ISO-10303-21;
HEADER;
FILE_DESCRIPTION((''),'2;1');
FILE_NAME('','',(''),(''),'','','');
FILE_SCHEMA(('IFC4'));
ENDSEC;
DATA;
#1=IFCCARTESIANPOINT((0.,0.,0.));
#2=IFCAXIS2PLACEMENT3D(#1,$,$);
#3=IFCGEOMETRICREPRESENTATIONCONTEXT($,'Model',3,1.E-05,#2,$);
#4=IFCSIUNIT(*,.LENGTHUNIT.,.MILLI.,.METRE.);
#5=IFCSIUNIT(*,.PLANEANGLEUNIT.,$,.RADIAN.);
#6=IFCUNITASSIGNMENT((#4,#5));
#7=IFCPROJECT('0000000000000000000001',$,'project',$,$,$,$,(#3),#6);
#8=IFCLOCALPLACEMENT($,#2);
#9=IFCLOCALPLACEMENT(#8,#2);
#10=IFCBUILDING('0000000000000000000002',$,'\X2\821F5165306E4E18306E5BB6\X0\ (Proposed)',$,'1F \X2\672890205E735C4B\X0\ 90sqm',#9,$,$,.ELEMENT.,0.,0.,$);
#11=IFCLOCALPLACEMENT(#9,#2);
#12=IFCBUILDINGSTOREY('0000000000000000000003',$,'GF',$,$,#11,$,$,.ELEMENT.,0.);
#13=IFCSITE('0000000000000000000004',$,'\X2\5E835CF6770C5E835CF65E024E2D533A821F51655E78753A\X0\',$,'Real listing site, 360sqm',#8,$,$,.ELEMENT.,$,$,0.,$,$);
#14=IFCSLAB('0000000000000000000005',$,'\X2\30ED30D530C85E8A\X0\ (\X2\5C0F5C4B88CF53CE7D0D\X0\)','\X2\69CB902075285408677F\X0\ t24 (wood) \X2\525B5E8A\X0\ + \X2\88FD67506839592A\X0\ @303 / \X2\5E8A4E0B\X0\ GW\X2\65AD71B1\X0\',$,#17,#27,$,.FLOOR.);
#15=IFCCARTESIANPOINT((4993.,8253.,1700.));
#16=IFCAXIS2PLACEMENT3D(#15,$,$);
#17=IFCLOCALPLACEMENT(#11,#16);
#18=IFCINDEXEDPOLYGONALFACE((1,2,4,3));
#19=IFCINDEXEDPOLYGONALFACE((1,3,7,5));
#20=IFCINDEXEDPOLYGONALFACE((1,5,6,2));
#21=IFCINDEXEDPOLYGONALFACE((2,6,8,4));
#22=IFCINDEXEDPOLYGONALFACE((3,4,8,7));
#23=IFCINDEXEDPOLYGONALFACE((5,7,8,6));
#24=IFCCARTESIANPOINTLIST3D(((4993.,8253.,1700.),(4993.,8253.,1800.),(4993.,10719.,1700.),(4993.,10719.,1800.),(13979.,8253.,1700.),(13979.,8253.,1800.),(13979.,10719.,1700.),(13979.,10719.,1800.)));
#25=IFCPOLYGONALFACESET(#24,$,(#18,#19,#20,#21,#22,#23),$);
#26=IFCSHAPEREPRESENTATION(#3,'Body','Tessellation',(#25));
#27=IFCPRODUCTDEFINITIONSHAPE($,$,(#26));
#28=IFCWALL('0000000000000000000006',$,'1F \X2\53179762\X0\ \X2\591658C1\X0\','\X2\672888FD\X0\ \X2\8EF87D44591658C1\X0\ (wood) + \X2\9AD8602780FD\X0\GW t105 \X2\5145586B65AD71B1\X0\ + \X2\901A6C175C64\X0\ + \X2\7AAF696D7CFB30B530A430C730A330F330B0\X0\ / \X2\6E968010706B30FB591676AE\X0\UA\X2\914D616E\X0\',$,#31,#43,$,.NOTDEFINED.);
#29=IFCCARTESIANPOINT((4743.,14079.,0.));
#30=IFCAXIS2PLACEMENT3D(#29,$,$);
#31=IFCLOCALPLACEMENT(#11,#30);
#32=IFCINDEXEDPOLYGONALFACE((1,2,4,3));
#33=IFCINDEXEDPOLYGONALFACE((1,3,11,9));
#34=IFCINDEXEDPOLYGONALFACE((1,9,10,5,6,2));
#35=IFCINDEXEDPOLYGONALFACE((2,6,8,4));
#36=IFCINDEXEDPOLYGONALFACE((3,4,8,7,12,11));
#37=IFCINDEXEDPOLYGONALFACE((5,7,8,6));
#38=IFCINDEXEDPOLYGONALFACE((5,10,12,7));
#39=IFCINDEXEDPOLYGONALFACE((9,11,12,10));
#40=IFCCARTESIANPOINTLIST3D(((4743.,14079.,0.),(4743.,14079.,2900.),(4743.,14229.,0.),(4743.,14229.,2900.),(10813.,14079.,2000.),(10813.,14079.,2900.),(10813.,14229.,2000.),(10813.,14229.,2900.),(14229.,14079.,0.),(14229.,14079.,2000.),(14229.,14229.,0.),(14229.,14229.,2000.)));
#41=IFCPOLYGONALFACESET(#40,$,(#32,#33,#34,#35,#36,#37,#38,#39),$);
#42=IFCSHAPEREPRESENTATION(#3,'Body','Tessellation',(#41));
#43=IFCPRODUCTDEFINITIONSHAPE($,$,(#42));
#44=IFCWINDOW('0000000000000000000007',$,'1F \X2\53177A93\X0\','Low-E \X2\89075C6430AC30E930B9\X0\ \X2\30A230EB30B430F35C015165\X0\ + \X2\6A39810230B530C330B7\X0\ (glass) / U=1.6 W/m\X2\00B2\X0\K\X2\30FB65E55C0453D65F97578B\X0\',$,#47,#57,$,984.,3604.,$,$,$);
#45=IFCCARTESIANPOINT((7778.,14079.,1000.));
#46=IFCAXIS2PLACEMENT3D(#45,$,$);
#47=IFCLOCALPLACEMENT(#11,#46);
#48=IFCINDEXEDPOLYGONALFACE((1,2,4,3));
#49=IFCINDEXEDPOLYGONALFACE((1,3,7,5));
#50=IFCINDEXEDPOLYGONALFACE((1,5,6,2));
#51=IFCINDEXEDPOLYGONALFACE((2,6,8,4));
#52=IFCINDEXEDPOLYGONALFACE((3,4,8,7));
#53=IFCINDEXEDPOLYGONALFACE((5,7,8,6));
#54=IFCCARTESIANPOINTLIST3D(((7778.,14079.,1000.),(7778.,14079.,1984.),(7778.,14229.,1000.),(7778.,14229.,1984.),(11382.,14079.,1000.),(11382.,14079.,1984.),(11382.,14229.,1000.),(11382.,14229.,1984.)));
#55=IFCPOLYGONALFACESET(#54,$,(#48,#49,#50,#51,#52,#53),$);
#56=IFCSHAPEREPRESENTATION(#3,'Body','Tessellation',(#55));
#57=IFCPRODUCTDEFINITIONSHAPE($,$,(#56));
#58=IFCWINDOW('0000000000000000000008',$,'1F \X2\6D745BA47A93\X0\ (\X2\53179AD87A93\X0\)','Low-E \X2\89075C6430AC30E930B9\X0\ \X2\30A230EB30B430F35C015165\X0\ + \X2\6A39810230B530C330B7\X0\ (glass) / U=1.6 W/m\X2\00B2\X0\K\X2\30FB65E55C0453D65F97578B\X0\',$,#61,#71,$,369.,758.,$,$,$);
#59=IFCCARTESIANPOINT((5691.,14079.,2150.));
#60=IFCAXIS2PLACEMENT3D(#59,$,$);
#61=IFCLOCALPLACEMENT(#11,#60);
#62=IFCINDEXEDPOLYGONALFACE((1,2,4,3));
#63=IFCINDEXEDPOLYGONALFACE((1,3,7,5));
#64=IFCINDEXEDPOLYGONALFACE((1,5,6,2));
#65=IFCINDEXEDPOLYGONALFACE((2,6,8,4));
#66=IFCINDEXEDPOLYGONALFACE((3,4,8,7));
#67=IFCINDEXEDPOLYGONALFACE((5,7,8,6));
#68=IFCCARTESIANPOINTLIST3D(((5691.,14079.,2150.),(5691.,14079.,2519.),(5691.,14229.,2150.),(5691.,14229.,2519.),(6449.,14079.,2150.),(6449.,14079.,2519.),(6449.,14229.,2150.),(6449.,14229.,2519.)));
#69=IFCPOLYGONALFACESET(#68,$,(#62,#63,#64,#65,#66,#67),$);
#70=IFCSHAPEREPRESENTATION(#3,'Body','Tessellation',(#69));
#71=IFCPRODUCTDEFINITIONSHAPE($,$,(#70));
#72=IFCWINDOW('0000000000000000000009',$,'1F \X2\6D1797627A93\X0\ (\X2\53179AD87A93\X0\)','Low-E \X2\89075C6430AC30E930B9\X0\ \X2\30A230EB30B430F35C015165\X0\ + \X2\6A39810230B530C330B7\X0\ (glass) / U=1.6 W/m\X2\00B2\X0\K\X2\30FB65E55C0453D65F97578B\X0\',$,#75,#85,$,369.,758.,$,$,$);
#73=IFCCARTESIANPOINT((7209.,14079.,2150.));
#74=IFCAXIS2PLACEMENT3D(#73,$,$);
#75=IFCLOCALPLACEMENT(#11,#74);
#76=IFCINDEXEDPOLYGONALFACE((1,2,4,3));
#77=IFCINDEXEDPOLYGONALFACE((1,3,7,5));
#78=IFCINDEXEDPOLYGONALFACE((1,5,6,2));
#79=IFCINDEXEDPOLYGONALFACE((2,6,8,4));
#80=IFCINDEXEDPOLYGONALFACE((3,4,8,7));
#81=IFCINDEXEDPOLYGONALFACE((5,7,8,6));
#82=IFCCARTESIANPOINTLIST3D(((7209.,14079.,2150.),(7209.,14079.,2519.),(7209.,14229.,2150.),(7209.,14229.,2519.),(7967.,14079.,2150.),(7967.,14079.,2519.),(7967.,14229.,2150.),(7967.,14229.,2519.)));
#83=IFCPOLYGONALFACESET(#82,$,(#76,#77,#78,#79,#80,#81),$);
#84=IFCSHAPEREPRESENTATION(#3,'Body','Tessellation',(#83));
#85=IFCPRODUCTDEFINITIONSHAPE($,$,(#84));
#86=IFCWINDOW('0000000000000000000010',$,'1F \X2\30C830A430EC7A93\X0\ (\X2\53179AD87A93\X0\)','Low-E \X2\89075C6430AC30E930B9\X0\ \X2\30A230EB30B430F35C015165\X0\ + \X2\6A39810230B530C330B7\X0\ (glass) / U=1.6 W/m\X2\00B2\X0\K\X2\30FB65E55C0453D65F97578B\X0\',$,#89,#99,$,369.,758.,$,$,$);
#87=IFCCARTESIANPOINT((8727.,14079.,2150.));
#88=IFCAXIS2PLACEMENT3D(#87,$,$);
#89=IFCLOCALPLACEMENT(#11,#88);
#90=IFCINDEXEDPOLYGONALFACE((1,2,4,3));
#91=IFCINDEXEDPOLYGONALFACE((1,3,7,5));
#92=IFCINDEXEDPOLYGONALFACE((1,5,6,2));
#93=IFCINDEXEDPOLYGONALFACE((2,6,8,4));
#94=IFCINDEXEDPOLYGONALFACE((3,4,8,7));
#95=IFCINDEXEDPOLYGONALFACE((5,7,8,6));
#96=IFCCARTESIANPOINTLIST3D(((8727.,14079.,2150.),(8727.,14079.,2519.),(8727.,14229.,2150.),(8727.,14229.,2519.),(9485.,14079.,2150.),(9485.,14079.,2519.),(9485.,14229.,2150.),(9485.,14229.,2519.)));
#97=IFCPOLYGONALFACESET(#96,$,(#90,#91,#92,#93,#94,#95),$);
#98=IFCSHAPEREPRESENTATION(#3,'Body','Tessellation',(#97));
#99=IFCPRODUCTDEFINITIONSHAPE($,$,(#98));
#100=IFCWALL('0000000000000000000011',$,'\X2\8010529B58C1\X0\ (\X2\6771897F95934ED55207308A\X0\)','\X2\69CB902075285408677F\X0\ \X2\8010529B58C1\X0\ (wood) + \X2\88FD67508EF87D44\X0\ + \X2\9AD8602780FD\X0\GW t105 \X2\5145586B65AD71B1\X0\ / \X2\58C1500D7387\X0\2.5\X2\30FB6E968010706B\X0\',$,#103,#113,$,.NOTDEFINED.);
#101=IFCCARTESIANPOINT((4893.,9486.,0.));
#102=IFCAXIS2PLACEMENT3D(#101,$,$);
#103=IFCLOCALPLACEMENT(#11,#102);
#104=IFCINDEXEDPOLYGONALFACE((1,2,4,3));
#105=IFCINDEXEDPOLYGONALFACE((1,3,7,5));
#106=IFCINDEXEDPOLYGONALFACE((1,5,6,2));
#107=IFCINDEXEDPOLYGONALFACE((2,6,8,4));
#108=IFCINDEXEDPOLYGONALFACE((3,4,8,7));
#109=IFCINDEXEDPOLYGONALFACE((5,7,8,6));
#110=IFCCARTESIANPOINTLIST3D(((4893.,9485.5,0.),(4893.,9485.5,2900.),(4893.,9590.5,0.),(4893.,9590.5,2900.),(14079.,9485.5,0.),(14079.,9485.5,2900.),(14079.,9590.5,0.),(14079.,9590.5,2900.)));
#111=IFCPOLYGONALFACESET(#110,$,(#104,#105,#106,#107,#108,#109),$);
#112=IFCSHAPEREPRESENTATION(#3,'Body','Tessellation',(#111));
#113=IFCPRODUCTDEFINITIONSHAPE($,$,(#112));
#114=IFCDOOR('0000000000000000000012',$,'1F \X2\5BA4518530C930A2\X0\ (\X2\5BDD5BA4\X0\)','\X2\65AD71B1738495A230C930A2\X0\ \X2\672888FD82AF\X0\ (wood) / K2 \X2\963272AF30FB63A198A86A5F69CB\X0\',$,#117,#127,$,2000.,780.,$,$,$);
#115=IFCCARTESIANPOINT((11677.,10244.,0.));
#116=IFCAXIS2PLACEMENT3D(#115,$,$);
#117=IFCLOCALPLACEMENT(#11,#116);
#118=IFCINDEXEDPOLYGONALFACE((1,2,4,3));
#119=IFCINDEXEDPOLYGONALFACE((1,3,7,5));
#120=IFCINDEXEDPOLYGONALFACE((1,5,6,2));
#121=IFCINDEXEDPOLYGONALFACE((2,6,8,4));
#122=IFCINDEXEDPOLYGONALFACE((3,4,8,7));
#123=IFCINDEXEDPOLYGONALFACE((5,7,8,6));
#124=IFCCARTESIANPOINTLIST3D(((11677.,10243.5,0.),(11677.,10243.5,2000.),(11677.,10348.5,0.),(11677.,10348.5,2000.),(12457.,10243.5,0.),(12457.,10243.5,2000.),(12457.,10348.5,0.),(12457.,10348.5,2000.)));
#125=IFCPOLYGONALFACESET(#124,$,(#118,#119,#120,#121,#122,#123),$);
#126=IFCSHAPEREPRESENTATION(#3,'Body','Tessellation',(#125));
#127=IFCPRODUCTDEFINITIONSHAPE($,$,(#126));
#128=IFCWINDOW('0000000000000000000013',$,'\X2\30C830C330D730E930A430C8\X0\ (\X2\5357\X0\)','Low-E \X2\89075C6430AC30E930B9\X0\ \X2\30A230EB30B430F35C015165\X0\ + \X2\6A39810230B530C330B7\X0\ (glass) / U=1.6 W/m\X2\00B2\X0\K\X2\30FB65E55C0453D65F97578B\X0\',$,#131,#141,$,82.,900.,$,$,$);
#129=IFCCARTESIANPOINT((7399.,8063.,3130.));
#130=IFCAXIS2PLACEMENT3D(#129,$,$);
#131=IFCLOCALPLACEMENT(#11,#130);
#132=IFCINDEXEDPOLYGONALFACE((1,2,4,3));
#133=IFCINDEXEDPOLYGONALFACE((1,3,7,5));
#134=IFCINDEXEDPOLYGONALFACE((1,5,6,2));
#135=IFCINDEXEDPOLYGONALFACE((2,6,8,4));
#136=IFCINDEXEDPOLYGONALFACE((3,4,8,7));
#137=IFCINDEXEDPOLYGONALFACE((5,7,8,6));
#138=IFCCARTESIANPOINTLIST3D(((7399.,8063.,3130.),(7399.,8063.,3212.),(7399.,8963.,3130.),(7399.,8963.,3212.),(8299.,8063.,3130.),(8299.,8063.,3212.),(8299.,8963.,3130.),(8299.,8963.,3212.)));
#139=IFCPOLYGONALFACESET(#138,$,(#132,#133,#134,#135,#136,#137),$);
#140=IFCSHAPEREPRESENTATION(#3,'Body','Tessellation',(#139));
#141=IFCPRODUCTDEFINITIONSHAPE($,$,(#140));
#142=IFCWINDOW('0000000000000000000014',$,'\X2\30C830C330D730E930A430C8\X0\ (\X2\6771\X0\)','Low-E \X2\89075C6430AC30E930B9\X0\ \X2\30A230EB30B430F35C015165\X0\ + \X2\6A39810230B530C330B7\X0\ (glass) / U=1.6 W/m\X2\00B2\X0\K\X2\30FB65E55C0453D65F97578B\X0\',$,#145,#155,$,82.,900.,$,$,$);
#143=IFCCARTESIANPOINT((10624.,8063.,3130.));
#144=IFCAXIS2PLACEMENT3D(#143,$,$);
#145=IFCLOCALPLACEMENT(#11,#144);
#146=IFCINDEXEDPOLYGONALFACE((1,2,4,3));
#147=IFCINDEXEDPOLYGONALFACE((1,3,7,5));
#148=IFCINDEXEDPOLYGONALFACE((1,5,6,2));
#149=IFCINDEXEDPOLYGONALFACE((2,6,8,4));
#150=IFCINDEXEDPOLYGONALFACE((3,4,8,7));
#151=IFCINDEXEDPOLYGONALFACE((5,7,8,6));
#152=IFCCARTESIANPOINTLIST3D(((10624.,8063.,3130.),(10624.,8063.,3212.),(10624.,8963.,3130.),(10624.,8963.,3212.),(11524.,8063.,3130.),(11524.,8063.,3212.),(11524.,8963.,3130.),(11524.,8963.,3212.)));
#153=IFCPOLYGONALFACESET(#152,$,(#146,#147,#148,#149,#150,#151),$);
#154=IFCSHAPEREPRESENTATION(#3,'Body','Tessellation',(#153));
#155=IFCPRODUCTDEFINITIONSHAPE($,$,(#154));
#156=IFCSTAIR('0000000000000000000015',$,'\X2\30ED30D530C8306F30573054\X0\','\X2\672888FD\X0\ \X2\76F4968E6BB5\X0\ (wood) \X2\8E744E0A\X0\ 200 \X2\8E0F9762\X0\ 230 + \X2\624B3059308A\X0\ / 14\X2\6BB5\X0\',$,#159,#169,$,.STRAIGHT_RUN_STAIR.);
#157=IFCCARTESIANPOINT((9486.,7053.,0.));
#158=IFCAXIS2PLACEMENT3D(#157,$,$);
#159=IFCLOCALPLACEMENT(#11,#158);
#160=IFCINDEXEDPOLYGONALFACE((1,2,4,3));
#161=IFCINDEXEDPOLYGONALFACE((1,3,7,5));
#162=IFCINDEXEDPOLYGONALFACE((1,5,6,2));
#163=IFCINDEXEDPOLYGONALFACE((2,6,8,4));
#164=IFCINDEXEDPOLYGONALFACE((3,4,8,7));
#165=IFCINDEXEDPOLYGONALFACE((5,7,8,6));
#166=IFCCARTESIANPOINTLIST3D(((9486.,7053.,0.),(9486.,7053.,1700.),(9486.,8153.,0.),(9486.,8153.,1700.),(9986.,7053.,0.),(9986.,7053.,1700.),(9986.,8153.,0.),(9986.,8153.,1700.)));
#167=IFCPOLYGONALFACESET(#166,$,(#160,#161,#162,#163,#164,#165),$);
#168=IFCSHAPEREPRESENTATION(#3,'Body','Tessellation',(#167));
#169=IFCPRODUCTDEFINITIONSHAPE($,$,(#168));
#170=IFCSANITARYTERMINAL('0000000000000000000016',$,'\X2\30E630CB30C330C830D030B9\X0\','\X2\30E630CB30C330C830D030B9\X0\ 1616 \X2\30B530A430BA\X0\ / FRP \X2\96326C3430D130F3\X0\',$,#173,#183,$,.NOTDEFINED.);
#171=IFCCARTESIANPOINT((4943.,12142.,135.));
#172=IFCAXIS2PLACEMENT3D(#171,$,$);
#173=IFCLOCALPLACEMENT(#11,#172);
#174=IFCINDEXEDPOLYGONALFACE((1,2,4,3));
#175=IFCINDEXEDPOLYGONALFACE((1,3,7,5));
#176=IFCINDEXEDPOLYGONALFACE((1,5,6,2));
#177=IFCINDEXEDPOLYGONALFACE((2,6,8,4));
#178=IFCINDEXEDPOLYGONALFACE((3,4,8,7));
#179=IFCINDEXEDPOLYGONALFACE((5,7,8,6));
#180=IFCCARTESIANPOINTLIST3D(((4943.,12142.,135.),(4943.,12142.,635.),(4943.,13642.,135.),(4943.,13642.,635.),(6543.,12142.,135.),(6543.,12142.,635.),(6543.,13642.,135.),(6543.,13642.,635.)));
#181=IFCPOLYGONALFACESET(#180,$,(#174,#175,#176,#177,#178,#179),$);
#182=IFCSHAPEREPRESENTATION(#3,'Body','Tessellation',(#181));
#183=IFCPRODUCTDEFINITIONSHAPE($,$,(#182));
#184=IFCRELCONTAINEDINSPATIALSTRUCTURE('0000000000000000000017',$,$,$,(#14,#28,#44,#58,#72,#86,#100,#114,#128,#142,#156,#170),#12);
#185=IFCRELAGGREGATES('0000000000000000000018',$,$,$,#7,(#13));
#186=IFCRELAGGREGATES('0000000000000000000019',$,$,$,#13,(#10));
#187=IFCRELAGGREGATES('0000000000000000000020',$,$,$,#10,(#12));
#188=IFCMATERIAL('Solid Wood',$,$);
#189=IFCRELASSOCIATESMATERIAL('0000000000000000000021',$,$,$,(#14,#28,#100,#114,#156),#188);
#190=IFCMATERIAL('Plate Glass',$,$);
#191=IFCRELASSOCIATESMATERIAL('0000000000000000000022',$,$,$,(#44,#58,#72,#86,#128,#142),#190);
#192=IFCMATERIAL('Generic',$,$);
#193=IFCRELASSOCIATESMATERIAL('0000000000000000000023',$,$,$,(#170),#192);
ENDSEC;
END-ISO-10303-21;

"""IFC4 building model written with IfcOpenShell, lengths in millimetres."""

from ifc_helpers import new_model, si_unit, frame, frame_2d, origin, place, context, project, spatial, rectangle, extrude, material, element, fill, save


model = new_model("IFC4")

# Units and contexts
model_context = context("Model", 3, precision=1e-05, world=origin())
ifc_project = project(units=[si_unit("LENGTHUNIT", "METRE", prefix="MILLI"), si_unit("PLANEANGLEUNIT", "RADIAN")], contexts=[model_context])

# Site, building, storey
site_placement = place(None, origin())
site = spatial("IfcSite", under=ifc_project, at=site_placement, Name="広島県広島市中区舟入幸町", ObjectType="Real listing site, 360sqm", CompositionType="ELEMENT", RefElevation=0.0)
building_placement = place(site_placement, origin())
building = spatial("IfcBuilding", under=site, at=building_placement, Name="舟入の丘の家 (Proposed)", ObjectType="1F 木造平屋 90sqm", CompositionType="ELEMENT", ElevationOfRefHeight=0.0, ElevationOfTerrain=0.0)
storey_placement = place(building_placement, origin())
storey = spatial("IfcBuildingStorey", under=building, at=storey_placement, Name="GF", CompositionType="ELEMENT", Elevation=0.0)

# Slab
ifc_material_1 = material(Name="Solid Wood")
slab_placement = place(storey_placement, frame((4993.0, 8253.0, 1700.0)))
element("IfcSlab", 1, at=slab_placement, inside=storey, material=ifc_material_1, Name="ロフト床 (小屋裏収納)", Description="構造用合板 t24 (wood) 剛床 + 製材根太 @303 / 床下 GW断熱", PredefinedType="FLOOR", context=model_context, shape_type="SweptSolid", body=[
    extrude(rectangle(XDim=8986.0, YDim=2466.0, at=frame_2d((4493.0, 1233.0))), frame((4993.0, 8253.0, 1700.0)), (0.0, 0.0, 1.0), 100.0),
])

# Wall, openings, windows
wall_1_placement = place(storey_placement, frame((4743.0, 14079.0, 0.0)))
wall_1 = element("IfcWall", 2, at=wall_1_placement, inside=storey, material=ifc_material_1, Name="1F 北面 外壁", Description="木製 軸組外壁 (wood) + 高性能GW t105 充填断熱 + 通気層 + 窯業系サイディング / 準耐火・外皮UA配慮", PredefinedType="NOTDEFINED", context=model_context, shape_type="SweptSolid", body=[
    extrude(rectangle(XDim=9486.0, YDim=150.0, at=frame_2d((4743.0, 75.0))), frame((4743.0, 14079.0, 0.0)), (0.0, 0.0, 1.0), 2900.0),
])
opening_1_placement = place(storey_placement, frame((7778.0, 14079.0, 1000.0)))
opening_1 = element("IfcOpeningElement", 3, at=opening_1_placement, cuts=wall_1, PredefinedType="NOTDEFINED", context=model_context, shape_type="SweptSolid", body=[
    extrude(rectangle(XDim=3604.0, YDim=150.0, at=frame_2d((1802.0, 75.0))), frame((7778.0, 14079.0, 1000.0)), (0.0, 0.0, 1.0), 984.0),
])
opening_2_placement = place(storey_placement, frame((5691.0, 14079.0, 2150.0)))
opening_2 = element("IfcOpeningElement", 4, at=opening_2_placement, cuts=wall_1, PredefinedType="NOTDEFINED", context=model_context, shape_type="SweptSolid", body=[
    extrude(rectangle(XDim=758.0, YDim=150.0, at=frame_2d((379.0, 75.0))), frame((5691.0, 14079.0, 2150.0)), (0.0, 0.0, 1.0), 369.0),
])
opening_3_placement = place(storey_placement, frame((7209.0, 14079.0, 2150.0)))
opening_3 = element("IfcOpeningElement", 5, at=opening_3_placement, cuts=wall_1, PredefinedType="NOTDEFINED", context=model_context, shape_type="SweptSolid", body=[
    extrude(rectangle(XDim=758.0, YDim=150.0, at=frame_2d((379.0, 75.0))), frame((7209.0, 14079.0, 2150.0)), (0.0, 0.0, 1.0), 369.0),
])
opening_4_placement = place(storey_placement, frame((8727.0, 14079.0, 2150.0)))
opening_4 = element("IfcOpeningElement", 6, at=opening_4_placement, cuts=wall_1, PredefinedType="NOTDEFINED", context=model_context, shape_type="SweptSolid", body=[
    extrude(rectangle(XDim=758.0, YDim=150.0, at=frame_2d((379.0, 75.0))), frame((8727.0, 14079.0, 2150.0)), (0.0, 0.0, 1.0), 369.0),
])
ifc_material_2 = material(Name="Plate Glass")
window_1_placement = place(storey_placement, frame((7778.0, 14079.0, 1000.0)))
window_1 = element("IfcWindow", 7, at=window_1_placement, inside=storey, material=ifc_material_2, Name="1F 北窓", Description="Low-E 複層ガラス アルゴン封入 + 樹脂サッシ (glass) / U=1.6 W/m²K・日射取得型", OverallHeight=984.0, OverallWidth=3604.0, context=model_context, shape_type="SweptSolid", body=[
    extrude(rectangle(XDim=3604.0, YDim=150.0, at=frame_2d((1802.0, 75.0))), frame((7778.0, 14079.0, 1000.0)), (0.0, 0.0, 1.0), 984.0),
])
fill(opening_1, window_1)
window_2_placement = place(storey_placement, frame((5691.0, 14079.0, 2150.0)))
window_2 = element("IfcWindow", 8, at=window_2_placement, inside=storey, material=ifc_material_2, Name="1F 浴室窓 (北高窓)", Description="Low-E 複層ガラス アルゴン封入 + 樹脂サッシ (glass) / U=1.6 W/m²K・日射取得型", OverallHeight=369.0, OverallWidth=758.0, context=model_context, shape_type="SweptSolid", body=[
    extrude(rectangle(XDim=758.0, YDim=150.0, at=frame_2d((379.0, 75.0))), frame((5691.0, 14079.0, 2150.0)), (0.0, 0.0, 1.0), 369.0),
])
fill(opening_2, window_2)
window_3_placement = place(storey_placement, frame((7209.0, 14079.0, 2150.0)))
window_3 = element("IfcWindow", 9, at=window_3_placement, inside=storey, material=ifc_material_2, Name="1F 洗面窓 (北高窓)", Description="Low-E 複層ガラス アルゴン封入 + 樹脂サッシ (glass) / U=1.6 W/m²K・日射取得型", OverallHeight=369.0, OverallWidth=758.0, context=model_context, shape_type="SweptSolid", body=[
    extrude(rectangle(XDim=758.0, YDim=150.0, at=frame_2d((379.0, 75.0))), frame((7209.0, 14079.0, 2150.0)), (0.0, 0.0, 1.0), 369.0),
])
fill(opening_3, window_3)
window_4_placement = place(storey_placement, frame((8727.0, 14079.0, 2150.0)))
window_4 = element("IfcWindow", 10, at=window_4_placement, inside=storey, material=ifc_material_2, Name="1F トイレ窓 (北高窓)", Description="Low-E 複層ガラス アルゴン封入 + 樹脂サッシ (glass) / U=1.6 W/m²K・日射取得型", OverallHeight=369.0, OverallWidth=758.0, context=model_context, shape_type="SweptSolid", body=[
    extrude(rectangle(XDim=758.0, YDim=150.0, at=frame_2d((379.0, 75.0))), frame((8727.0, 14079.0, 2150.0)), (0.0, 0.0, 1.0), 369.0),
])
fill(opening_4, window_4)

# Wall
wall_2_placement = place(storey_placement, frame((4893.0, 9486.0, 0.0)))
element("IfcWall", 11, at=wall_2_placement, inside=storey, material=ifc_material_1, Name="耐力壁 (東西間仕切り)", Description="構造用合板 耐力壁 (wood) + 製材軸組 + 高性能GW t105 充填断熱 / 壁倍率2.5・準耐火", PredefinedType="NOTDEFINED", context=model_context, shape_type="SweptSolid", body=[
    extrude(rectangle(XDim=9186.0, YDim=105.0, at=frame_2d((4593.0, 52.0))), frame((4893.0, 9486.0, 0.0)), (0.0, 0.0, 1.0), 2900.0),
])

# Door
door_1_placement = place(storey_placement, frame((11677.0, 10244.0, 0.0)))
element("IfcDoor", 12, at=door_1_placement, inside=storey, material=ifc_material_1, Name="1F 室内ドア (寝室)", Description="断熱玄関ドア 木製芯 (wood) / K2 防犯・採風機構", OverallHeight=2000.0, OverallWidth=780.0, context=model_context, shape_type="SweptSolid", body=[
    extrude(rectangle(XDim=780.0, YDim=105.0, at=frame_2d((390.0, 52.0))), frame((11677.0, 10244.0, 0.0)), (0.0, 0.0, 1.0), 2000.0),
])

# Windows
window_5_placement = place(storey_placement, frame((7399.0, 8063.0, 3130.0)))
element("IfcWindow", 13, at=window_5_placement, inside=storey, material=ifc_material_2, Name="トップライト (南)", Description="Low-E 複層ガラス アルゴン封入 + 樹脂サッシ (glass) / U=1.6 W/m²K・日射取得型", OverallHeight=82.0, OverallWidth=900.0, context=model_context, shape_type="SweptSolid", body=[
    extrude(rectangle(XDim=900.0, YDim=900.0, at=frame_2d((450.0, 450.0))), frame((7399.0, 8063.0, 3130.0)), (0.0, 0.0, 1.0), 82.0),
])
window_6_placement = place(storey_placement, frame((10624.0, 8063.0, 3130.0)))
element("IfcWindow", 14, at=window_6_placement, inside=storey, material=ifc_material_2, Name="トップライト (東)", Description="Low-E 複層ガラス アルゴン封入 + 樹脂サッシ (glass) / U=1.6 W/m²K・日射取得型", OverallHeight=82.0, OverallWidth=900.0, context=model_context, shape_type="SweptSolid", body=[
    extrude(rectangle(XDim=900.0, YDim=900.0, at=frame_2d((450.0, 450.0))), frame((10624.0, 8063.0, 3130.0)), (0.0, 0.0, 1.0), 82.0),
])

# Stair
stair_placement = place(storey_placement, frame((9486.0, 7053.0, 0.0)))
element("IfcStair", 15, at=stair_placement, inside=storey, material=ifc_material_1, Name="ロフトはしご", Description="木製 直階段 (wood) 蹴上 200 踏面 230 + 手すり / 14段", PredefinedType="STRAIGHT_RUN_STAIR", context=model_context, shape_type="SweptSolid", body=[
    extrude(rectangle(XDim=500.0, YDim=1100.0, at=frame_2d((250.0, 550.0))), frame((9486.0, 7053.0, 0.0)), (0.0, 0.0, 1.0), 1700.0),
])

# Sanitary terminal
ifc_material_3 = material(Name="Generic")
sanitary_terminal_1_placement = place(storey_placement, frame((4943.0, 12142.0, 135.0)))
element("IfcSanitaryTerminal", 16, at=sanitary_terminal_1_placement, inside=storey, material=ifc_material_3, Name="ユニットバス", Description="ユニットバス 1616 サイズ / FRP 防水パン", PredefinedType="NOTDEFINED", context=model_context, shape_type="SweptSolid", body=[
    extrude(rectangle(XDim=1600.0, YDim=1500.0, at=frame_2d((800.0, 750.0))), frame((4943.0, 12142.0, 135.0)), (0.0, 0.0, 1.0), 500.0),
])

save(model, "model.ifc")
